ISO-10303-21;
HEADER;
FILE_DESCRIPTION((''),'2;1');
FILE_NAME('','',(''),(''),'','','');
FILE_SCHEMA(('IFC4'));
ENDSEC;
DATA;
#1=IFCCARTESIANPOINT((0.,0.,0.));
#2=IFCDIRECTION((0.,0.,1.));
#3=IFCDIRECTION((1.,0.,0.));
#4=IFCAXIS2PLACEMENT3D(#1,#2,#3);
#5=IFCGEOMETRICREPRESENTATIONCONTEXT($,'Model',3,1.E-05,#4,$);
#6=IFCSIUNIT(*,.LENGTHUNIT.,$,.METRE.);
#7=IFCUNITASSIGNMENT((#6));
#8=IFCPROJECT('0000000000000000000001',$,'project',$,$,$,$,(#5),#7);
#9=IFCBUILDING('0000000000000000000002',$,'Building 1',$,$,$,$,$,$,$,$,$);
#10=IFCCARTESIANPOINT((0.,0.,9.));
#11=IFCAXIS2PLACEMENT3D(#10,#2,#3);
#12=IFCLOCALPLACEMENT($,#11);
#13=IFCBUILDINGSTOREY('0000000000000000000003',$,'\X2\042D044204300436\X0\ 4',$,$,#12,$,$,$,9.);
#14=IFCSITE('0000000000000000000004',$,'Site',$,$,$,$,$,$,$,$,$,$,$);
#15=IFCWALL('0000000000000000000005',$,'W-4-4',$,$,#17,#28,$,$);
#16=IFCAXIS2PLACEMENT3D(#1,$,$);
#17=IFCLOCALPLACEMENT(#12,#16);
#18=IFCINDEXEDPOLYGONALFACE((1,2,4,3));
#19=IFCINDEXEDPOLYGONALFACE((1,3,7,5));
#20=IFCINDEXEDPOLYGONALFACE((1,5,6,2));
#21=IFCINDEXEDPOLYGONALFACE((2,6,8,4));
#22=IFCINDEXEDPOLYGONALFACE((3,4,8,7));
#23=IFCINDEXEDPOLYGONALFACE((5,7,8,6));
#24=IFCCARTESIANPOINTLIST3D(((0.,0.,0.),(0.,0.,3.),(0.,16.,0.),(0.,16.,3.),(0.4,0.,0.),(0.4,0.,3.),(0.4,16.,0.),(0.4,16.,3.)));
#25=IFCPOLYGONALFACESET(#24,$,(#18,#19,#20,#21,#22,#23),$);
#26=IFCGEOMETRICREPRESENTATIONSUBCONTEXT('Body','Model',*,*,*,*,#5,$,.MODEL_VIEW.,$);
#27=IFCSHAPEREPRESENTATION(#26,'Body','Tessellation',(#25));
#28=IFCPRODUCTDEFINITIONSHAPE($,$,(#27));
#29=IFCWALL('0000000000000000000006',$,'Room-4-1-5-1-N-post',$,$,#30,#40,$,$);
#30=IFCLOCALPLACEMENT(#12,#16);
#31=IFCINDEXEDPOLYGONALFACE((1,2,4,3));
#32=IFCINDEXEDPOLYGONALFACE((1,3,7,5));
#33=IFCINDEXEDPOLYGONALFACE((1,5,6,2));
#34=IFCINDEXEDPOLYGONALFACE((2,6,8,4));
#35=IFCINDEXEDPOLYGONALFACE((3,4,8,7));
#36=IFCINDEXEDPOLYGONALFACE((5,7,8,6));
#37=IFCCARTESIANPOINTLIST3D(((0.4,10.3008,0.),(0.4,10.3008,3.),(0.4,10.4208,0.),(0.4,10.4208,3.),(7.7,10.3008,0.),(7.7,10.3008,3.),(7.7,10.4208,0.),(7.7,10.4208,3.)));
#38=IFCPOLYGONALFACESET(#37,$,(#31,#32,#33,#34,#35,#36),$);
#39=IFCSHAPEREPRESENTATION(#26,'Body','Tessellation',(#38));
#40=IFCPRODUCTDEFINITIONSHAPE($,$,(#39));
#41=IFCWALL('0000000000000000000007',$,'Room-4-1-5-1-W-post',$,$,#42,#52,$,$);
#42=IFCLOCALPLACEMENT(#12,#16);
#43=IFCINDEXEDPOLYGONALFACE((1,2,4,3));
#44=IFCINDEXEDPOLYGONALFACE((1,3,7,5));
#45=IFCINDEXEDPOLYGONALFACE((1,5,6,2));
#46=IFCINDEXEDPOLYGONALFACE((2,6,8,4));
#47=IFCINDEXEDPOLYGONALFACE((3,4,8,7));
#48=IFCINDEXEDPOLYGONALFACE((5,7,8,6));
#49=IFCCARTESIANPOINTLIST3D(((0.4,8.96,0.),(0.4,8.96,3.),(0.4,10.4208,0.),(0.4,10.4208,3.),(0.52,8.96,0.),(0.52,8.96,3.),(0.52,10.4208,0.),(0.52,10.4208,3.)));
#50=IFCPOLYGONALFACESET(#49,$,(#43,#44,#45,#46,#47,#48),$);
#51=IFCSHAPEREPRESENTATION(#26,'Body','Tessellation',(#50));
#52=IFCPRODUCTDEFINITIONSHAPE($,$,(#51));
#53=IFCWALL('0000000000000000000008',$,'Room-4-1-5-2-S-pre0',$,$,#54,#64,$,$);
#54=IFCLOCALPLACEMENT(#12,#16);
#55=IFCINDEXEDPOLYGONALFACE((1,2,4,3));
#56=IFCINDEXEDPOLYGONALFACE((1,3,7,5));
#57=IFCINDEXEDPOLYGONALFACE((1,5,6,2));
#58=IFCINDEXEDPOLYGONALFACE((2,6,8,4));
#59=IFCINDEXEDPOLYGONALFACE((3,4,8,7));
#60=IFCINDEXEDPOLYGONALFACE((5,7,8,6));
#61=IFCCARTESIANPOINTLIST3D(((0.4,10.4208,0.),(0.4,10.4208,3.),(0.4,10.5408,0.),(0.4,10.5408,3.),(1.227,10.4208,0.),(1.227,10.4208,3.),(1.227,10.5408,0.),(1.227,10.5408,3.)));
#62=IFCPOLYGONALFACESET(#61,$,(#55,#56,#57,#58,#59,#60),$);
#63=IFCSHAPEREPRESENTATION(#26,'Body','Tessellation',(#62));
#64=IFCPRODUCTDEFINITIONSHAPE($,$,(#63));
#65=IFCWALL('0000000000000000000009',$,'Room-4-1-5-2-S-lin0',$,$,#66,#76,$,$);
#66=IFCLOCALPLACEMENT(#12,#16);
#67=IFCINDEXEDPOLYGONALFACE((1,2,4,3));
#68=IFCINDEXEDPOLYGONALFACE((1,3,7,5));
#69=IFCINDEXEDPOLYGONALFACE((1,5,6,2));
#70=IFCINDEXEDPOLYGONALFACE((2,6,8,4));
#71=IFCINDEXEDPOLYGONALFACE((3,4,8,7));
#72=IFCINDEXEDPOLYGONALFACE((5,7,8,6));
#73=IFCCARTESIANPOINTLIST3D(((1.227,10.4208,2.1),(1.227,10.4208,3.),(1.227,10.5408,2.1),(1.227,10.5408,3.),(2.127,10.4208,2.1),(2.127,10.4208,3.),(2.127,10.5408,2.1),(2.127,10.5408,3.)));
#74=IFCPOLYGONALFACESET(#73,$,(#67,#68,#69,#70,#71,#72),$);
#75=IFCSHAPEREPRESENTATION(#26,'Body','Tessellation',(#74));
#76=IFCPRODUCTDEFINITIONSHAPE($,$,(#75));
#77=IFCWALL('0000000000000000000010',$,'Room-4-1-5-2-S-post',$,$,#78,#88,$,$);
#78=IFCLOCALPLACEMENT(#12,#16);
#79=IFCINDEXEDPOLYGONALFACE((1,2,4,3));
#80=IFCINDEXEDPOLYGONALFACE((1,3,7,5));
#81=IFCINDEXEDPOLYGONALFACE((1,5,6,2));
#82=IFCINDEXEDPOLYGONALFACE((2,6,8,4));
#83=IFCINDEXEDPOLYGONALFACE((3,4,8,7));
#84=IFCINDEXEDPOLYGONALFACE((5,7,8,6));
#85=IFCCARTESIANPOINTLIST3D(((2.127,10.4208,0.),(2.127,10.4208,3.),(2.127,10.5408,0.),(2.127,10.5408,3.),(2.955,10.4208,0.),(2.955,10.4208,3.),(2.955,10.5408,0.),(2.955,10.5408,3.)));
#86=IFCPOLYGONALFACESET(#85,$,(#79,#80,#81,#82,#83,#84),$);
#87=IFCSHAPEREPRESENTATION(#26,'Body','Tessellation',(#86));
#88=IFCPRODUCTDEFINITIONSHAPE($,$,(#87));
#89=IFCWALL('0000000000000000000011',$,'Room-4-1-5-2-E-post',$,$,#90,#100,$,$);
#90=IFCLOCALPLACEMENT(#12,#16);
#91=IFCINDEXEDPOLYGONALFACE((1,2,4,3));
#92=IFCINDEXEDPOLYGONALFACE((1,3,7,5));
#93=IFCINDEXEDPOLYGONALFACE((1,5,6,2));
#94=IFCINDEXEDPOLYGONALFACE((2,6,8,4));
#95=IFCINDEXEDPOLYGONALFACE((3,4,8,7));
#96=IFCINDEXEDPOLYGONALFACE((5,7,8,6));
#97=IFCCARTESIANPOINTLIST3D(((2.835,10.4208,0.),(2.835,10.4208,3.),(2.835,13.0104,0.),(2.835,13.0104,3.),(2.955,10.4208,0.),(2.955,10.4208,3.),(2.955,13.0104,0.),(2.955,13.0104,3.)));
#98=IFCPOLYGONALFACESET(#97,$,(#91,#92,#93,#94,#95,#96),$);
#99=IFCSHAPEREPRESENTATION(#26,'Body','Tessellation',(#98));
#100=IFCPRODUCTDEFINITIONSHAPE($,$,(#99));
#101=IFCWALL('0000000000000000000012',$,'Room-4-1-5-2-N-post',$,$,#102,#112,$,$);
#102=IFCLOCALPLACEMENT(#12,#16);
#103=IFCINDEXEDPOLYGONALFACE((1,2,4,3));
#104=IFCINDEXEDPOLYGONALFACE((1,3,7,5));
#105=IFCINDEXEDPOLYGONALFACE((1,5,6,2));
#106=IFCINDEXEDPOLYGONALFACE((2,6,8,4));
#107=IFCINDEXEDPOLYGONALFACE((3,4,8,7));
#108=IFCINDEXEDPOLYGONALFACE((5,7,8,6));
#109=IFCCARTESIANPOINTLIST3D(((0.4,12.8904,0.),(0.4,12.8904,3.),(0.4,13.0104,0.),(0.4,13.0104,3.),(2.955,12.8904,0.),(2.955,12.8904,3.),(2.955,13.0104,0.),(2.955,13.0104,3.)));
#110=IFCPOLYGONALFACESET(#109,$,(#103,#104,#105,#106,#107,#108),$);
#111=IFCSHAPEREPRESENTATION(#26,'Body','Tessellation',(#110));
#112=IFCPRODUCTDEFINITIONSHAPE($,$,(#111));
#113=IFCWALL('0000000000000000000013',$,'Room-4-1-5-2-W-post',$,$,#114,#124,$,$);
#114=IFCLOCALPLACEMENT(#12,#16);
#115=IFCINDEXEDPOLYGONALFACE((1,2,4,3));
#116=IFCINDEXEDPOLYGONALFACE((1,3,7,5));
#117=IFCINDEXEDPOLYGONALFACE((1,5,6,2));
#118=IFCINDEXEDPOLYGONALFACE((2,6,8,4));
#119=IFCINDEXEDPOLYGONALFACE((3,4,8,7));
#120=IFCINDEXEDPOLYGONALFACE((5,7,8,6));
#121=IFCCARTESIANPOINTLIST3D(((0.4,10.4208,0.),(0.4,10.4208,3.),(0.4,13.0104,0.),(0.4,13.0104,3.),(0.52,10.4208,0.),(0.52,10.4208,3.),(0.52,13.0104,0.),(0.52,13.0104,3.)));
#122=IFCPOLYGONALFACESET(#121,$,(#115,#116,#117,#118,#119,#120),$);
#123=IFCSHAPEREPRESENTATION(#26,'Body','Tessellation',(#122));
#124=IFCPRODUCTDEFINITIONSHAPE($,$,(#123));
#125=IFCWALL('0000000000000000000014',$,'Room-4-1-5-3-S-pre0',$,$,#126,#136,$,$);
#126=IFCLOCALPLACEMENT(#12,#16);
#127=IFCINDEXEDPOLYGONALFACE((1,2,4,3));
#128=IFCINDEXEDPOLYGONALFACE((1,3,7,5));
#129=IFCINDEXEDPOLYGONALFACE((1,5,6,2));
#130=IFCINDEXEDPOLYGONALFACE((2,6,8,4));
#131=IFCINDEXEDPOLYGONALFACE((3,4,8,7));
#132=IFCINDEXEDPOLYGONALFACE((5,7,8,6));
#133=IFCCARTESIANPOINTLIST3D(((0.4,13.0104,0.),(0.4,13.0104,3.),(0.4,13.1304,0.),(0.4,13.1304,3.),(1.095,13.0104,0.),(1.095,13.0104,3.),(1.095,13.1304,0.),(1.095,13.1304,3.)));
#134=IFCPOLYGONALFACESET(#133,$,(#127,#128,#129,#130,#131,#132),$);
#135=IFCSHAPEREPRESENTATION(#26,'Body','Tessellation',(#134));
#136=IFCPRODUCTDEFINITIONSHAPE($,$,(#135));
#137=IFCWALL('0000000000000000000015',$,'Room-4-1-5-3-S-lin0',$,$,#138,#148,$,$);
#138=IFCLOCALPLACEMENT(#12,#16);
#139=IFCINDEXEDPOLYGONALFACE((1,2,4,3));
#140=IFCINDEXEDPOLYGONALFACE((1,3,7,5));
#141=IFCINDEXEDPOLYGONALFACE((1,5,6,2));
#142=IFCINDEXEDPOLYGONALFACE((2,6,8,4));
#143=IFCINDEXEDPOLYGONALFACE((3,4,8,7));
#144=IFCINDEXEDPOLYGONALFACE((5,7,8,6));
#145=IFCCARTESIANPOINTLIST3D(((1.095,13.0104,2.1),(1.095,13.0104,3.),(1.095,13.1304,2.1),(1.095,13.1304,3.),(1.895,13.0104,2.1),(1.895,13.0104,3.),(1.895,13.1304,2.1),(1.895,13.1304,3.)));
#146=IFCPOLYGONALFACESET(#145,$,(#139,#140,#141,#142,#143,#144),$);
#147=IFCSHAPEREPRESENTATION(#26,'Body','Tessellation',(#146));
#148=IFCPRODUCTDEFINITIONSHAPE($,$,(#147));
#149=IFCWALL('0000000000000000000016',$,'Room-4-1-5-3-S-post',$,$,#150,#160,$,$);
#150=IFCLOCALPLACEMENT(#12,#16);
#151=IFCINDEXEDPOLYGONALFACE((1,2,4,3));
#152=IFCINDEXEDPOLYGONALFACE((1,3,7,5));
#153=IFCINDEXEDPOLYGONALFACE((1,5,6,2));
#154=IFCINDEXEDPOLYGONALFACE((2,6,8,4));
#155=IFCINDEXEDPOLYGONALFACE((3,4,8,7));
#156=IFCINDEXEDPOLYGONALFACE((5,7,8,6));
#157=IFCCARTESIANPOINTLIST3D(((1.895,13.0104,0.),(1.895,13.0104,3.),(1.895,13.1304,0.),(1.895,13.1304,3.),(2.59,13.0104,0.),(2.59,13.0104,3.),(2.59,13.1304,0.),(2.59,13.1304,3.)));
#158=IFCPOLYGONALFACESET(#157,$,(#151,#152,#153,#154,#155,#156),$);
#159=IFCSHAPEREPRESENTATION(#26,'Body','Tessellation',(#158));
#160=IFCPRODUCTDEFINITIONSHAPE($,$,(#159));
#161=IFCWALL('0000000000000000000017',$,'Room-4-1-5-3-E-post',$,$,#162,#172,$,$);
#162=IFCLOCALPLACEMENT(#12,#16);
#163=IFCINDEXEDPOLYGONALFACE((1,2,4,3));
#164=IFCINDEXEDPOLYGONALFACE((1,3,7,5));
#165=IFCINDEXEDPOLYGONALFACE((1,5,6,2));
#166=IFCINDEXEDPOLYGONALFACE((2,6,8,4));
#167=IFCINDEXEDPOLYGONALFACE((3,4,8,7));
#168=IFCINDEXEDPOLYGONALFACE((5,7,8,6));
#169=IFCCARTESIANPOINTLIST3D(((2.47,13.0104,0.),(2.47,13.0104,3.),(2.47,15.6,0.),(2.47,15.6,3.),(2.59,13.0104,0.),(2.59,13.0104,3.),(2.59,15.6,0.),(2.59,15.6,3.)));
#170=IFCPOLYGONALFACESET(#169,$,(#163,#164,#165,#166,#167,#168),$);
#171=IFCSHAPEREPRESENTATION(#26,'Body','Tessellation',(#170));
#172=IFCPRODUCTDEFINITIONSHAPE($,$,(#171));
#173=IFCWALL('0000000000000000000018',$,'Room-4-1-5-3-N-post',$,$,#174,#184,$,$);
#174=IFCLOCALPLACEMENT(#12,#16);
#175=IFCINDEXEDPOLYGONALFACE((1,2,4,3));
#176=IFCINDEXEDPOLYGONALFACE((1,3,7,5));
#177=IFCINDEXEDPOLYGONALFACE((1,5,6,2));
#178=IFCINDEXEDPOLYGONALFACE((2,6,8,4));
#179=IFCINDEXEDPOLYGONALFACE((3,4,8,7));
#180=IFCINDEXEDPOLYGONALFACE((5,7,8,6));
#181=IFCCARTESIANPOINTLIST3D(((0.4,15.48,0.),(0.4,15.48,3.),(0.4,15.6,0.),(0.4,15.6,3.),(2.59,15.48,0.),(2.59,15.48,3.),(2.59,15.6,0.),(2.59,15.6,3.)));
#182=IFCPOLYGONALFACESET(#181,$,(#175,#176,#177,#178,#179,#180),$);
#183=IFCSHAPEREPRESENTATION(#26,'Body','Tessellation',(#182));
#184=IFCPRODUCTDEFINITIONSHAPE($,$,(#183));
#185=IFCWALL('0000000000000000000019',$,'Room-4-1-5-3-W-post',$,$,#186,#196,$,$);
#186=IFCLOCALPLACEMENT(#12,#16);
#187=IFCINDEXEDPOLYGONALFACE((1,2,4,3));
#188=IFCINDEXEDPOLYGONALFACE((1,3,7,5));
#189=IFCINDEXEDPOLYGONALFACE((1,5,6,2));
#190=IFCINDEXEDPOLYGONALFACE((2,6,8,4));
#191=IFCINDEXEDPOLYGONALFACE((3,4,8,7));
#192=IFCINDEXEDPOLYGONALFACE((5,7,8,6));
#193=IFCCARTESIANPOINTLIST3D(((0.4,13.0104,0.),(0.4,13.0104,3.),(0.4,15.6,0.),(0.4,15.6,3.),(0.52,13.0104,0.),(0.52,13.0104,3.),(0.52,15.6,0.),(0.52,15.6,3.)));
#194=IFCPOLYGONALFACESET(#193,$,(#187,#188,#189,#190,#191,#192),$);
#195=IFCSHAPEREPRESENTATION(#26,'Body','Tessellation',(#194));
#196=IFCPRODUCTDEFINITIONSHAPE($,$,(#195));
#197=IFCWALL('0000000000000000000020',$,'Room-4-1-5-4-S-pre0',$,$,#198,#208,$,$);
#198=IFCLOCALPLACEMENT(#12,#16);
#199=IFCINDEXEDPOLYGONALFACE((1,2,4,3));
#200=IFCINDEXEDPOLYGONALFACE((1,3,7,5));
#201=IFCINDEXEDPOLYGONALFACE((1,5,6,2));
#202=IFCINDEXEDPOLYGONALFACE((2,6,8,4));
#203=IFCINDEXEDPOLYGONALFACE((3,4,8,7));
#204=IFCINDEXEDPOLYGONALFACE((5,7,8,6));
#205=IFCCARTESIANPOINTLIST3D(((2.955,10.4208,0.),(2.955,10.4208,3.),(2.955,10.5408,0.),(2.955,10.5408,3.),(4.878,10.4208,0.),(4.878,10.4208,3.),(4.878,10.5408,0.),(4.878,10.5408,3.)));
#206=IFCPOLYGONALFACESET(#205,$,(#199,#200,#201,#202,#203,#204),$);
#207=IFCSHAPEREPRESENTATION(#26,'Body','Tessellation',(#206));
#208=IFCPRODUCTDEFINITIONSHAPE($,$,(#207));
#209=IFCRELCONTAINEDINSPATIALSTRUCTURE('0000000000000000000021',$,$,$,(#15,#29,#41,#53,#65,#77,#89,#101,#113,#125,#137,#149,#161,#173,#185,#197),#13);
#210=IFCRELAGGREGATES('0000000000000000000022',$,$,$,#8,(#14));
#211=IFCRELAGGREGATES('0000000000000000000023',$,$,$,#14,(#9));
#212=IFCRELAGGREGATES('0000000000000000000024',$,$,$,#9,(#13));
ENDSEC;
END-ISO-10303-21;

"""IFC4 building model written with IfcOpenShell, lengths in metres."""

from ifc_helpers import new_model, si_unit, frame, origin_with_axes, place, context, subcontext, project, spatial, indexed_curve, outline, extrude, element, save


model = new_model("IFC4")

# Units and contexts
model_context = context("Model", 3, precision=1e-05, world=origin_with_axes())
body_context = subcontext(model_context, "Body", "Model", "MODEL_VIEW")
ifc_project = project(units=[si_unit("LENGTHUNIT", "METRE")], contexts=[model_context])

# Site, building, storey
site = spatial("IfcSite", under=ifc_project, Name="Site")
building = spatial("IfcBuilding", under=site, Name="Building 1")
storey_placement = place(None, frame((0.0, 0.0, 9.0), z_axis=(0.0, 0.0, 1.0), x_axis=(1.0, 0.0, 0.0)))
storey = spatial("IfcBuildingStorey", under=building, at=storey_placement, Name="Этаж 4", Elevation=9.0)

# Walls
wall_1_placement = place(storey_placement, frame((0.0, 16.0, 0.0), z_axis=(0.0, 0.0, 1.0), x_axis=(0.0, -1.0, 0.0)))
element("IfcWall", 1, at=wall_1_placement, inside=storey, Name="W-4-4", context=body_context, shape_type="SweptSolid", body=[
    extrude(outline(indexed_curve([(0.0, 0.0), (0.0, 0.4), (16.0, 0.4), (16.0, 0.0), (0.0, 0.0)], self_intersect=False)), origin_with_axes(), (0.0, 0.0, 1.0), 3.0),
])
wall_2_placement = place(storey_placement, frame((7.7, 10.4208, 0.0), z_axis=(0.0, 0.0, 1.0), x_axis=(-1.0, 0.0, 0.0)))
element("IfcWall", 2, at=wall_2_placement, inside=storey, Name="Room-4-1-5-1-N-post", context=body_context, shape_type="SweptSolid", body=[
    extrude(outline(indexed_curve([(0.0, 0.0), (0.0, 0.12), (7.3, 0.12), (7.3, 0.0), (0.0, 0.0)], self_intersect=False)), origin_with_axes(), (0.0, 0.0, 1.0), 3.0),
])
wall_3_placement = place(storey_placement, frame((0.4, 10.4208, 0.0), z_axis=(0.0, 0.0, 1.0), x_axis=(0.0, -1.0, 0.0)))
element("IfcWall", 3, at=wall_3_placement, inside=storey, Name="Room-4-1-5-1-W-post", context=body_context, shape_type="SweptSolid", body=[
    extrude(outline(indexed_curve([(0.0, 0.0), (0.0, 0.12), (1.4608, 0.12), (1.4608, 0.0), (0.0, 0.0)], self_intersect=False)), origin_with_axes(), (0.0, 0.0, 1.0), 3.0),
])
wall_4_placement = place(storey_placement, frame((0.4, 10.4208, 0.0), z_axis=(0.0, 0.0, 1.0), x_axis=(1.0, 0.0, 0.0)))
element("IfcWall", 4, at=wall_4_placement, inside=storey, Name="Room-4-1-5-2-S-pre0", context=body_context, shape_type="SweptSolid", body=[
    extrude(outline(indexed_curve([(0.0, 0.0), (0.0, 0.12), (0.827, 0.12), (0.827, 0.0), (0.0, 0.0)], self_intersect=False)), origin_with_axes(), (0.0, 0.0, 1.0), 3.0),
])
wall_5_placement = place(storey_placement, frame((1.227, 10.4208, 2.1), z_axis=(0.0, 0.0, 1.0), x_axis=(1.0, 0.0, 0.0)))
element("IfcWall", 5, at=wall_5_placement, inside=storey, Name="Room-4-1-5-2-S-lin0", context=body_context, shape_type="SweptSolid", body=[
    extrude(outline(indexed_curve([(0.0, 0.0), (0.0, 0.12), (0.9, 0.12), (0.9, 0.0), (0.0, 0.0)], self_intersect=False)), origin_with_axes(), (0.0, 0.0, 1.0), 0.9),
])
wall_6_placement = place(storey_placement, frame((2.127, 10.4208, 0.0), z_axis=(0.0, 0.0, 1.0), x_axis=(1.0, 0.0, 0.0)))
element("IfcWall", 6, at=wall_6_placement, inside=storey, Name="Room-4-1-5-2-S-post", context=body_context, shape_type="SweptSolid", body=[
    extrude(outline(indexed_curve([(0.0, 0.0), (0.0, 0.12), (0.828, 0.12), (0.828, 0.0), (0.0, 0.0)], self_intersect=False)), origin_with_axes(), (0.0, 0.0, 1.0), 3.0),
])
wall_7_placement = place(storey_placement, frame((2.955, 10.4208, 0.0), z_axis=(0.0, 0.0, 1.0), x_axis=(0.0, 1.0, 0.0)))
element("IfcWall", 7, at=wall_7_placement, inside=storey, Name="Room-4-1-5-2-E-post", context=body_context, shape_type="SweptSolid", body=[
    extrude(outline(indexed_curve([(0.0, 0.0), (0.0, 0.12), (2.5896, 0.12), (2.5896, 0.0), (0.0, 0.0)], self_intersect=False)), origin_with_axes(), (0.0, 0.0, 1.0), 3.0),
])
wall_8_placement = place(storey_placement, frame((2.955, 13.0104, 0.0), z_axis=(0.0, 0.0, 1.0), x_axis=(-1.0, 0.0, 0.0)))
element("IfcWall", 8, at=wall_8_placement, inside=storey, Name="Room-4-1-5-2-N-post", context=body_context, shape_type="SweptSolid", body=[
    extrude(outline(indexed_curve([(0.0, 0.0), (0.0, 0.12), (2.555, 0.12), (2.555, 0.0), (0.0, 0.0)], self_intersect=False)), origin_with_axes(), (0.0, 0.0, 1.0), 3.0),
])
wall_9_placement = place(storey_placement, frame((0.4, 13.0104, 0.0), z_axis=(0.0, 0.0, 1.0), x_axis=(0.0, -1.0, 0.0)))
element("IfcWall", 9, at=wall_9_placement, inside=storey, Name="Room-4-1-5-2-W-post", context=body_context, shape_type="SweptSolid", body=[
    extrude(outline(indexed_curve([(0.0, 0.0), (0.0, 0.12), (2.5896, 0.12), (2.5896, 0.0), (0.0, 0.0)], self_intersect=False)), origin_with_axes(), (0.0, 0.0, 1.0), 3.0),
])
wall_10_placement = place(storey_placement, frame((0.4, 13.0104, 0.0), z_axis=(0.0, 0.0, 1.0), x_axis=(1.0, 0.0, 0.0)))
element("IfcWall", 10, at=wall_10_placement, inside=storey, Name="Room-4-1-5-3-S-pre0", context=body_context, shape_type="SweptSolid", body=[
    extrude(outline(indexed_curve([(0.0, 0.0), (0.0, 0.12), (0.695, 0.12), (0.695, 0.0), (0.0, 0.0)], self_intersect=False)), origin_with_axes(), (0.0, 0.0, 1.0), 3.0),
])
wall_11_placement = place(storey_placement, frame((1.095, 13.0104, 2.1), z_axis=(0.0, 0.0, 1.0), x_axis=(1.0, 0.0, 0.0)))
element("IfcWall", 11, at=wall_11_placement, inside=storey, Name="Room-4-1-5-3-S-lin0", context=body_context, shape_type="SweptSolid", body=[
    extrude(outline(indexed_curve([(0.0, 0.0), (0.0, 0.12), (0.8, 0.12), (0.8, 0.0), (0.0, 0.0)], self_intersect=False)), origin_with_axes(), (0.0, 0.0, 1.0), 0.9),
])
wall_12_placement = place(storey_placement, frame((1.895, 13.0104, 0.0), z_axis=(0.0, 0.0, 1.0), x_axis=(1.0, 0.0, 0.0)))
element("IfcWall", 12, at=wall_12_placement, inside=storey, Name="Room-4-1-5-3-S-post", context=body_context, shape_type="SweptSolid", body=[
    extrude(outline(indexed_curve([(0.0, 0.0), (0.0, 0.12), (0.695, 0.12), (0.695, 0.0), (0.0, 0.0)], self_intersect=False)), origin_with_axes(), (0.0, 0.0, 1.0), 3.0),
])
wall_13_placement = place(storey_placement, frame((2.59, 13.0104, 0.0), z_axis=(0.0, 0.0, 1.0), x_axis=(0.0, 1.0, 0.0)))
element("IfcWall", 13, at=wall_13_placement, inside=storey, Name="Room-4-1-5-3-E-post", context=body_context, shape_type="SweptSolid", body=[
    extrude(outline(indexed_curve([(0.0, 0.0), (0.0, 0.12), (2.5896, 0.12), (2.5896, 0.0), (0.0, 0.0)], self_intersect=False)), origin_with_axes(), (0.0, 0.0, 1.0), 3.0),
])
wall_14_placement = place(storey_placement, frame((2.59, 15.6, 0.0), z_axis=(0.0, 0.0, 1.0), x_axis=(-1.0, 0.0, 0.0)))
element("IfcWall", 14, at=wall_14_placement, inside=storey, Name="Room-4-1-5-3-N-post", context=body_context, shape_type="SweptSolid", body=[
    extrude(outline(indexed_curve([(0.0, 0.0), (0.0, 0.12), (2.19, 0.12), (2.19, 0.0), (0.0, 0.0)], self_intersect=False)), origin_with_axes(), (0.0, 0.0, 1.0), 3.0),
])
wall_15_placement = place(storey_placement, frame((0.4, 15.6, 0.0), z_axis=(0.0, 0.0, 1.0), x_axis=(0.0, -1.0, 0.0)))
element("IfcWall", 15, at=wall_15_placement, inside=storey, Name="Room-4-1-5-3-W-post", context=body_context, shape_type="SweptSolid", body=[
    extrude(outline(indexed_curve([(0.0, 0.0), (0.0, 0.12), (2.5896, 0.12), (2.5896, 0.0), (0.0, 0.0)], self_intersect=False)), origin_with_axes(), (0.0, 0.0, 1.0), 3.0),
])
wall_16_placement = place(storey_placement, frame((2.955, 10.4208, 0.0), z_axis=(0.0, 0.0, 1.0), x_axis=(1.0, 0.0, 0.0)))
element("IfcWall", 16, at=wall_16_placement, inside=storey, Name="Room-4-1-5-4-S-pre0", context=body_context, shape_type="SweptSolid", body=[
    extrude(outline(indexed_curve([(0.0, 0.0), (0.0, 0.12), (1.923, 0.12), (1.923, 0.0), (0.0, 0.0)], self_intersect=False)), origin_with_axes(), (0.0, 0.0, 1.0), 3.0),
])

save(model, "model.ifc")
